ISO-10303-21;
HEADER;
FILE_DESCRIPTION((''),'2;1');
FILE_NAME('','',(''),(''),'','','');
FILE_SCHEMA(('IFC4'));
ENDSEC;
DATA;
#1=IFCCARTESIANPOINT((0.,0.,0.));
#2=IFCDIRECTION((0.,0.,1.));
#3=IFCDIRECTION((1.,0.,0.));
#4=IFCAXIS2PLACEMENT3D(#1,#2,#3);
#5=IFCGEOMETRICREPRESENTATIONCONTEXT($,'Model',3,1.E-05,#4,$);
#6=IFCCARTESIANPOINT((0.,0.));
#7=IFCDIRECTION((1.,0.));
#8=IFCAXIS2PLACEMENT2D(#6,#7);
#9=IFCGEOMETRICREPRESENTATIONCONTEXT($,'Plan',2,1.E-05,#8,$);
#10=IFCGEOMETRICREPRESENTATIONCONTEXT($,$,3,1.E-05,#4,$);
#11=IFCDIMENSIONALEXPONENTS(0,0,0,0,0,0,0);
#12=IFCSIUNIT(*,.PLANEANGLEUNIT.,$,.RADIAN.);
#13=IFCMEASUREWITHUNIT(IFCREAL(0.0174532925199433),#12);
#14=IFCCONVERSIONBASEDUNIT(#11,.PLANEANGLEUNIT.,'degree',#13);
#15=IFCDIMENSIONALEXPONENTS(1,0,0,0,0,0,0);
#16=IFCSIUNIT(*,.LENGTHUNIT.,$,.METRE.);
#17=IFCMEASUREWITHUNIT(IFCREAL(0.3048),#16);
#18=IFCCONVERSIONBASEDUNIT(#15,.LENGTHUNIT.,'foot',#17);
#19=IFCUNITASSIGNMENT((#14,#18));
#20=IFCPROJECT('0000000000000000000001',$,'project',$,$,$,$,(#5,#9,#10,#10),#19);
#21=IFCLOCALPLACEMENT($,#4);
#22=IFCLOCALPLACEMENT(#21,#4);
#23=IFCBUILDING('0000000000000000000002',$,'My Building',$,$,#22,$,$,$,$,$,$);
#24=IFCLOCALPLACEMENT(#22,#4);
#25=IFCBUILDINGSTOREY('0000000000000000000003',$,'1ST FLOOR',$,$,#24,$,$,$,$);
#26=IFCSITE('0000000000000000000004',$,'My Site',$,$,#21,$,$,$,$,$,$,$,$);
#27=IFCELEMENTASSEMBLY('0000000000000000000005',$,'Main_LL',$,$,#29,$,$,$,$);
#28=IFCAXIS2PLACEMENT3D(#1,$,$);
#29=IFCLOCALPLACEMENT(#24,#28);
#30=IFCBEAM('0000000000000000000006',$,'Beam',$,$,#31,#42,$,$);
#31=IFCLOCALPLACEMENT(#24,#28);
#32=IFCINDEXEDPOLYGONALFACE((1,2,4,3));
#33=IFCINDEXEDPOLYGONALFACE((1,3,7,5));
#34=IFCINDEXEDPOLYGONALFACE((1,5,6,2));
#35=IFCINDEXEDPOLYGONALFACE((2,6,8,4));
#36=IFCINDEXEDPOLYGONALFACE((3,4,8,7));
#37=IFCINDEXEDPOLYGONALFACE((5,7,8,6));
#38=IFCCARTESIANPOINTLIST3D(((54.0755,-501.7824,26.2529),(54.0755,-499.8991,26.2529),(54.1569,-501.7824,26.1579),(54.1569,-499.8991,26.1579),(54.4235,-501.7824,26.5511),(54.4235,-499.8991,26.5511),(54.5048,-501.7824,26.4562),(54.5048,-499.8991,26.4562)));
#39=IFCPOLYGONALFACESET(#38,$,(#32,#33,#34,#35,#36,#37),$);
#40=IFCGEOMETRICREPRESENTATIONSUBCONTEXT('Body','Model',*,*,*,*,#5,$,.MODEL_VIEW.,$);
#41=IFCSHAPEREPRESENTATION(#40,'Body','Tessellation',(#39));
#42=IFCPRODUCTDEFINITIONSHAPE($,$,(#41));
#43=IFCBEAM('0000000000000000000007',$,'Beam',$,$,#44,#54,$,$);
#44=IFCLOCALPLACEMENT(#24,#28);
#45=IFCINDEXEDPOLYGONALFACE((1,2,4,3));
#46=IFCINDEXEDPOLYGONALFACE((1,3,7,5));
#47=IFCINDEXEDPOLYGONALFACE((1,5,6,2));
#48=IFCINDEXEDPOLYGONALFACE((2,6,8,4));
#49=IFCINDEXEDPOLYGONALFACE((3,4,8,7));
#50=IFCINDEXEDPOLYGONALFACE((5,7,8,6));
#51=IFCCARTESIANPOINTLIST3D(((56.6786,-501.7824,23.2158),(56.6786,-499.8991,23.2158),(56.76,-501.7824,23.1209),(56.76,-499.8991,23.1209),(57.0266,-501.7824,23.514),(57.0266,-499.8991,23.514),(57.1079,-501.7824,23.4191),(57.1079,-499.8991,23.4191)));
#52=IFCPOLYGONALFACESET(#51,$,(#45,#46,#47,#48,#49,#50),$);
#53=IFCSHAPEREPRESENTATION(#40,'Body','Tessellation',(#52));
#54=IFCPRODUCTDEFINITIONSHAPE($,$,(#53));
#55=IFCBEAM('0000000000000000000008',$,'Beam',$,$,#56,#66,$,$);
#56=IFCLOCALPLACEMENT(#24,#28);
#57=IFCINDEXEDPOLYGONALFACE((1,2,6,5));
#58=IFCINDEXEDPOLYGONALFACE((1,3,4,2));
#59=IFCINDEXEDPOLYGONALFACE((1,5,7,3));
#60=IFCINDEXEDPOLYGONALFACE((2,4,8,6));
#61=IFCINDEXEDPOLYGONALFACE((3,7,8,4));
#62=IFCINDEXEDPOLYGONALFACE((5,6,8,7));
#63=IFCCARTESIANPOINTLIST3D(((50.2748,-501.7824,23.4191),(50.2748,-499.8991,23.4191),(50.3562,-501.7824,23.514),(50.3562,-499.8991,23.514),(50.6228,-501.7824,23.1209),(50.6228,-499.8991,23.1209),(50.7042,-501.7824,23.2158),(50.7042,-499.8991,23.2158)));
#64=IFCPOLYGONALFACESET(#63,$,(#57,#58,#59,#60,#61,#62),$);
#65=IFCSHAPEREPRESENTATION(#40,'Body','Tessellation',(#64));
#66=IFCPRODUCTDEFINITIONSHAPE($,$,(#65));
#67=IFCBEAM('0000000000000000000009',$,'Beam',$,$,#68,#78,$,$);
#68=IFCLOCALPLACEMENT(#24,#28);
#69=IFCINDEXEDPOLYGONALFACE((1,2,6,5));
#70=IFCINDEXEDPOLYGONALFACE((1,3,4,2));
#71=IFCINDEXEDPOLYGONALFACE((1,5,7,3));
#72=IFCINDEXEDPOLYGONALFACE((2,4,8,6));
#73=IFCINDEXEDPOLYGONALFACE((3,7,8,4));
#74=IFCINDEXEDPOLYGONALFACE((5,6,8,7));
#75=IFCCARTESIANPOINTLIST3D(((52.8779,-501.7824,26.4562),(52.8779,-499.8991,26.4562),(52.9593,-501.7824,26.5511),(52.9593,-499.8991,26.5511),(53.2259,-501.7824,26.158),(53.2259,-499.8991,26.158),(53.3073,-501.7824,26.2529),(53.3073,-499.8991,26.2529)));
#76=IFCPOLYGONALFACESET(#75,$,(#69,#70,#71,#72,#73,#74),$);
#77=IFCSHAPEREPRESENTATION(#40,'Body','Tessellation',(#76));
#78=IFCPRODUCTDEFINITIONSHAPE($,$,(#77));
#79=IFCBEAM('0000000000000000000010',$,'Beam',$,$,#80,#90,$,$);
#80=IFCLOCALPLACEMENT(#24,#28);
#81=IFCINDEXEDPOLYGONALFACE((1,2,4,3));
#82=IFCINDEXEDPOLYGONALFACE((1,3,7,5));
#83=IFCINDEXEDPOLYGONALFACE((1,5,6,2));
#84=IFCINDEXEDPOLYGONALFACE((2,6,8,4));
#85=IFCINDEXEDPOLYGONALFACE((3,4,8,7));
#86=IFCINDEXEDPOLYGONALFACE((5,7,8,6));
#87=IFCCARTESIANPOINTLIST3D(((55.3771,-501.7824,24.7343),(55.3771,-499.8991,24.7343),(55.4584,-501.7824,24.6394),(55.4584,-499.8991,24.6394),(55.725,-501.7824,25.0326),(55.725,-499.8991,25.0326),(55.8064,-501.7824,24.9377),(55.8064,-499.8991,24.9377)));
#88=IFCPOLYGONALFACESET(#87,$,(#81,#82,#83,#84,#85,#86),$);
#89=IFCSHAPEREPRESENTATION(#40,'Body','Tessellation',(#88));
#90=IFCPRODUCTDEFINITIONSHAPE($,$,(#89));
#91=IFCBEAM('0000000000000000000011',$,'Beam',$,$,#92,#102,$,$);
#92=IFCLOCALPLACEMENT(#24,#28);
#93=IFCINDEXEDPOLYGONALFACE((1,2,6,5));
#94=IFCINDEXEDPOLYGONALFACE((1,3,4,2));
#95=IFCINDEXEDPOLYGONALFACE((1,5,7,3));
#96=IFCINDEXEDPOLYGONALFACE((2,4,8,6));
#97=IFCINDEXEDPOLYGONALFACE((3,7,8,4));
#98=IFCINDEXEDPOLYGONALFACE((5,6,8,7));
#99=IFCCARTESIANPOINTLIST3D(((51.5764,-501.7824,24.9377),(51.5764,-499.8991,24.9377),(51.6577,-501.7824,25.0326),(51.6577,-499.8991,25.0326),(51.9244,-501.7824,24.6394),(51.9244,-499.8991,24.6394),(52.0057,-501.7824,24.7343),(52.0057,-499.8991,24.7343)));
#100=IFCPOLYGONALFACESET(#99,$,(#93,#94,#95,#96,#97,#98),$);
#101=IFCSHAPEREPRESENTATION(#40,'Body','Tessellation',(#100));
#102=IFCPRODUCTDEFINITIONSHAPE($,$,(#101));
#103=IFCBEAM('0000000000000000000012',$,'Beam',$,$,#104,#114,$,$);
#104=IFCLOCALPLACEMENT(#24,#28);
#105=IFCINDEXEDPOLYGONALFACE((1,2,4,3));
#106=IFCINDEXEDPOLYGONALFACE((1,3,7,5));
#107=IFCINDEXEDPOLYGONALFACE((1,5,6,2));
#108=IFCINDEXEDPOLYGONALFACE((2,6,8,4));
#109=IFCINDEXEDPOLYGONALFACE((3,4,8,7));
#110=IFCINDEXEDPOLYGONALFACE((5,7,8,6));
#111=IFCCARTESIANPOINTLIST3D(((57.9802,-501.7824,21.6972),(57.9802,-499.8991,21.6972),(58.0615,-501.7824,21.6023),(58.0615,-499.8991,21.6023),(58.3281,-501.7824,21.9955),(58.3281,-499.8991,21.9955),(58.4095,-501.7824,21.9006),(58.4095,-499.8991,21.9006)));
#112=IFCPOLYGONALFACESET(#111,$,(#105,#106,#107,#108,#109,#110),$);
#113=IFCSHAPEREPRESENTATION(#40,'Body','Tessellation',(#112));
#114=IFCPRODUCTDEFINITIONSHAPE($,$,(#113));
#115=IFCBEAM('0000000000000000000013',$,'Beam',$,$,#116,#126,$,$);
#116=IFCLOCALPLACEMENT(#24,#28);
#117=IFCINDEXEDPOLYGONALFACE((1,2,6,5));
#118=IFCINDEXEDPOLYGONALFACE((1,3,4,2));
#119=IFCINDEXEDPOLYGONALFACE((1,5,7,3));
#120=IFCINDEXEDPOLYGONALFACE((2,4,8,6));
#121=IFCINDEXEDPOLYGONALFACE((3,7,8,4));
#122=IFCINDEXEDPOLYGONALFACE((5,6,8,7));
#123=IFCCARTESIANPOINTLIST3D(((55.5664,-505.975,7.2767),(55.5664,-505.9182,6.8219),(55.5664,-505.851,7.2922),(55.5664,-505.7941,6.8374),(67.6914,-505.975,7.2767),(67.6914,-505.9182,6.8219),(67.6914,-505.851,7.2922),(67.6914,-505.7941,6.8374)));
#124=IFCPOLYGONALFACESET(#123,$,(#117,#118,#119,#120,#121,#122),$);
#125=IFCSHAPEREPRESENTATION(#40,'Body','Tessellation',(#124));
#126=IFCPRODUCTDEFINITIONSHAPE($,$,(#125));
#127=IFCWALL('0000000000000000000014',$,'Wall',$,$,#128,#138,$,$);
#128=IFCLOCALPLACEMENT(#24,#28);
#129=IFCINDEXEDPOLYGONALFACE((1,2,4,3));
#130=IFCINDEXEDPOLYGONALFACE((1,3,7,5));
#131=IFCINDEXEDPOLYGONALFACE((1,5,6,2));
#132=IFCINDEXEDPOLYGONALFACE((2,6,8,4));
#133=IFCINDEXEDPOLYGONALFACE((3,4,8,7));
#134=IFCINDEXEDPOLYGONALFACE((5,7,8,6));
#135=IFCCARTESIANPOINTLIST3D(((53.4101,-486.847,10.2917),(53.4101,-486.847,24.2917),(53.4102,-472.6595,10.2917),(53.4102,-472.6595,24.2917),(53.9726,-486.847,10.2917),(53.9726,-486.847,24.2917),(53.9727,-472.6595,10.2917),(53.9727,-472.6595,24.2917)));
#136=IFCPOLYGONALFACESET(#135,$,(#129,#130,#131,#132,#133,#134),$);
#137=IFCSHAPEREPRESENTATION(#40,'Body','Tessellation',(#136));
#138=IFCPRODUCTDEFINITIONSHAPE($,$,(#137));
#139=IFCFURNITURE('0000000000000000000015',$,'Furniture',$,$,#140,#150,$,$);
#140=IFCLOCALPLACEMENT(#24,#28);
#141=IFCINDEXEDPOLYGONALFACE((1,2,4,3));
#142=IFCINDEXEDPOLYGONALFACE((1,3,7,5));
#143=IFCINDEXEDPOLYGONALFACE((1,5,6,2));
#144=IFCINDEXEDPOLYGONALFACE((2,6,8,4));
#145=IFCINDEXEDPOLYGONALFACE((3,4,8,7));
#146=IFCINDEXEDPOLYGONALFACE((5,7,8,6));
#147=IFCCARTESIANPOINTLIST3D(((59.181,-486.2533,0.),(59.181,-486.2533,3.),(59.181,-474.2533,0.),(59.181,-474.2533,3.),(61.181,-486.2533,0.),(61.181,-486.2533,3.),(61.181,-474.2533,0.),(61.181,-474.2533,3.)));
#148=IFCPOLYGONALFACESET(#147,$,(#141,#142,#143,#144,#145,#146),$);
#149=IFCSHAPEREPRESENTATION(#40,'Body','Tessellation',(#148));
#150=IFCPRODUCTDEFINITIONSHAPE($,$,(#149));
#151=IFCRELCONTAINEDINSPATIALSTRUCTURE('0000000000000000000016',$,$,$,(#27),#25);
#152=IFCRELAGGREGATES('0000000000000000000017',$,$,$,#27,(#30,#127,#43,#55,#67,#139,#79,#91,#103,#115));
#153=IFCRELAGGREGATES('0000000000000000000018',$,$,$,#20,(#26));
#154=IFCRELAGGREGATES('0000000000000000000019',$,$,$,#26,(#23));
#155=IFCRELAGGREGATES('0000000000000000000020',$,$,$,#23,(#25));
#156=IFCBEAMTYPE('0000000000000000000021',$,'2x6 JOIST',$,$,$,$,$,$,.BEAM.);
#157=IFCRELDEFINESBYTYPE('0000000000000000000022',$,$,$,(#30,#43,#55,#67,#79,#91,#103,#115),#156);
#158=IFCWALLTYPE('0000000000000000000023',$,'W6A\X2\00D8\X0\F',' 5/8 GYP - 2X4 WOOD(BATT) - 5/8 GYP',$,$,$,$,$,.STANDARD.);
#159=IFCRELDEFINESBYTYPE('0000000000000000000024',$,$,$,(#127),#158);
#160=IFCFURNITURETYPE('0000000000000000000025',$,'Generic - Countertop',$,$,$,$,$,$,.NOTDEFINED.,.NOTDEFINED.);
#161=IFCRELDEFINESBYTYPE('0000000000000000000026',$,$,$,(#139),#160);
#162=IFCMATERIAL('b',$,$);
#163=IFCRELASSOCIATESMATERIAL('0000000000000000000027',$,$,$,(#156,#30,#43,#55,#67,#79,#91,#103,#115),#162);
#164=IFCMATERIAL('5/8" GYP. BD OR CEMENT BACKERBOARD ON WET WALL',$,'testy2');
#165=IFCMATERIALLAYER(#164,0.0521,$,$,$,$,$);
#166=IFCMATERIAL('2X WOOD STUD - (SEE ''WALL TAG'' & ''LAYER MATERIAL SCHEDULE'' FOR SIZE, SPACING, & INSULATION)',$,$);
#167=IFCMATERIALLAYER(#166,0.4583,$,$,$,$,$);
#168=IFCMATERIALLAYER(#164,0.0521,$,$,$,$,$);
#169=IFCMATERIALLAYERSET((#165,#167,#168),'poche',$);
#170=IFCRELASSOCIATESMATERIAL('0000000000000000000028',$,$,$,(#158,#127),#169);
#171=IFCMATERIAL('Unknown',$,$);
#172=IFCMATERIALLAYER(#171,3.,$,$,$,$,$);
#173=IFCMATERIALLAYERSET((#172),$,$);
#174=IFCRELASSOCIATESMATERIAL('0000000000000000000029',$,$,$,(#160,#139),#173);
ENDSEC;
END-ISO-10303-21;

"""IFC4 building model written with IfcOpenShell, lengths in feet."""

from ifc_helpers import new_model, entity, si_unit, converted_unit, frame, origin_with_axes, origin_2d_with_axis, place, context, subcontext, project, spatial, line, indexed_curve, rectangle, outline, extrude, material, layer, layer_set, layer_usage, material_profile, profile_set, profile_usage, type_object, element, aggregate, save


model = new_model("IFC4")

# Units and contexts
model_context = context("Model", 3, precision=1e-05, world=origin_with_axes())
plan_context = context("Plan", 2, precision=1e-05, world=origin_2d_with_axis())
context_of_model = context(None, 3, precision=1e-05, world=origin_with_axes())
body_context = subcontext(model_context, "Body", "Model", "MODEL_VIEW")
ifc_project = project(units=[converted_unit("PLANEANGLEUNIT", "degree", entity("IfcReal", 0.0174532925199433), si_unit("PLANEANGLEUNIT", "RADIAN"), dimensions=[0, 0, 0, 0, 0, 0, 0]), converted_unit("LENGTHUNIT", "foot", entity("IfcReal", 0.3048), si_unit("LENGTHUNIT", "METRE"), dimensions=[1, 0, 0, 0, 0, 0, 0])], contexts=[model_context, plan_context, context_of_model, context_of_model])

# Site, building, storey
site_placement = place(None, origin_with_axes())
site = spatial("IfcSite", under=ifc_project, at=site_placement, Name="My Site")
building_placement = place(site_placement, origin_with_axes())
building = spatial("IfcBuilding", under=site, at=building_placement, Name="My Building")
storey_placement = place(building_placement, origin_with_axes())
storey = spatial("IfcBuildingStorey", under=building, at=storey_placement, Name="1ST FLOOR")

# Element assembly, beams, wall, furniture
assembly_placement = place(storey_placement, origin_with_axes())
assembly = element("IfcElementAssembly", 1, at=assembly_placement, inside=storey, Name="Main_LL")
ifc_material_1 = material(Name="b")
ifc_material_profile_1 = material_profile(ifc_material_1, rectangle(XDim=0.125, YDim=0.4583))
ifc_profile_set_1 = profile_set([ifc_material_profile_1])
ifc_profile_usage_1 = profile_usage(ifc_profile_set_1, cardinal=8)
beam_type_1 = type_object("IfcBeamType", Name="2x6 JOIST", PredefinedType="BEAM", material=ifc_profile_set_1)
beam_1_placement = place(assembly_placement, frame((54.4642, -499.8991, 26.5037), z_axis=(0.0, -1.0, 0.0), x_axis=(0.650774, 0.0, -0.759271)))
beam_1 = element("IfcBeam", 2, at=beam_1_placement, type_object=beam_type_1, material=ifc_profile_usage_1, Name="Beam", context=body_context, shape_type="SweptSolid", body=[
    extrude(rectangle(XDim=0.125, YDim=0.4583), frame((0.0, -0.2291, 0.0)), (0.0, 0.0, 1.0), 1.8833),
])
ifc_profile_usage_2 = profile_usage(ifc_profile_set_1, cardinal=8)
beam_2_placement = place(assembly_placement, frame((57.0673, -499.8991, 23.4666), z_axis=(0.0, -1.0, 0.0), x_axis=(0.650774, 0.0, -0.759271)))
beam_2 = element("IfcBeam", 3, at=beam_2_placement, type_object=beam_type_1, material=ifc_profile_usage_2, Name="Beam", context=body_context, shape_type="SweptSolid", body=[
    extrude(rectangle(XDim=0.125, YDim=0.4583), frame((0.0, -0.2291, 0.0)), (0.0, 0.0, 1.0), 1.8833),
])
ifc_profile_usage_3 = profile_usage(ifc_profile_set_1, cardinal=8)
beam_3_placement = place(assembly_placement, frame((50.3155, -499.8991, 23.4666), z_axis=(0.0, -1.0, 0.0), x_axis=(0.650774, 0.0, 0.759271)))
beam_3 = element("IfcBeam", 4, at=beam_3_placement, type_object=beam_type_1, material=ifc_profile_usage_3, Name="Beam", context=body_context, shape_type="SweptSolid", body=[
    extrude(rectangle(XDim=0.125, YDim=0.4583), frame((0.0, -0.2291, 0.0)), (0.0, 0.0, 1.0), 1.8833),
])
ifc_profile_usage_4 = profile_usage(ifc_profile_set_1, cardinal=8)
beam_4_placement = place(assembly_placement, frame((52.9186, -499.8991, 26.5037), z_axis=(0.0, -1.0, 0.0), x_axis=(0.650774, 0.0, 0.759271)))
beam_4 = element("IfcBeam", 5, at=beam_4_placement, type_object=beam_type_1, material=ifc_profile_usage_4, Name="Beam", context=body_context, shape_type="SweptSolid", body=[
    extrude(rectangle(XDim=0.125, YDim=0.4583), frame((0.0, -0.2291, 0.0)), (0.0, 0.0, 1.0), 1.8833),
])
ifc_profile_usage_5 = profile_usage(ifc_profile_set_1, cardinal=8)
beam_5_placement = place(assembly_placement, frame((55.7657, -499.8991, 24.9851), z_axis=(0.0, -1.0, 0.0), x_axis=(0.650774, 0.0, -0.759271)))
beam_5 = element("IfcBeam", 6, at=beam_5_placement, type_object=beam_type_1, material=ifc_profile_usage_5, Name="Beam", context=body_context, shape_type="SweptSolid", body=[
    extrude(rectangle(XDim=0.125, YDim=0.4583), frame((0.0, -0.2291, 0.0)), (0.0, 0.0, 1.0), 1.8833),
])
ifc_profile_usage_6 = profile_usage(ifc_profile_set_1, cardinal=8)
beam_6_placement = place(assembly_placement, frame((51.6171, -499.8991, 24.9851), z_axis=(0.0, -1.0, 0.0), x_axis=(0.650774, 0.0, 0.759271)))
beam_6 = element("IfcBeam", 7, at=beam_6_placement, type_object=beam_type_1, material=ifc_profile_usage_6, Name="Beam", context=body_context, shape_type="SweptSolid", body=[
    extrude(rectangle(XDim=0.125, YDim=0.4583), frame((0.0, -0.2291, 0.0)), (0.0, 0.0, 1.0), 1.8833),
])
ifc_profile_usage_7 = profile_usage(ifc_profile_set_1, cardinal=8)
beam_7_placement = place(assembly_placement, frame((58.3688, -499.8991, 21.948), z_axis=(0.0, -1.0, 0.0), x_axis=(0.650774, 0.0, -0.759271)))
beam_7 = element("IfcBeam", 8, at=beam_7_placement, type_object=beam_type_1, material=ifc_profile_usage_7, Name="Beam", context=body_context, shape_type="SweptSolid", body=[
    extrude(rectangle(XDim=0.125, YDim=0.4583), frame((0.0, -0.2291, 0.0)), (0.0, 0.0, 1.0), 1.8833),
])
ifc_profile_usage_8 = profile_usage(ifc_profile_set_1, cardinal=5)
beam_8_placement = place(assembly_placement, frame((55.5664, -505.8846, 7.0571), z_axis=(1.0, 0.0, 0.0), x_axis=(0.0, 0.992267, 0.124121)))
beam_8 = element("IfcBeam", 9, at=beam_8_placement, type_object=beam_type_1, material=ifc_profile_usage_8, Name="Beam", context=body_context, shape_type="SweptSolid", body=[
    extrude(rectangle(XDim=0.125, YDim=0.4583), origin_with_axes(), (0.0, 0.0, 1.0), 12.125),
])
ifc_material_2 = material(Name="5/8\" GYP. BD OR CEMENT BACKERBOARD ON WET WALL", Category="testy2")
ifc_material_3 = material(Name="2X WOOD STUD - (SEE 'WALL TAG' & 'LAYER MATERIAL SCHEDULE' FOR SIZE, SPACING, & INSULATION)")
ifc_layer_1 = layer(ifc_material_2, 0.0521)
ifc_layer_2 = layer(ifc_material_3, 0.4583)
ifc_layer_3 = layer(ifc_material_2, 0.0521)
ifc_layer_set_1 = layer_set([ifc_layer_1, ifc_layer_2, ifc_layer_3], Name="poche")
ifc_layer_usage_1 = layer_usage(ifc_layer_set_1, "AXIS2", "POSITIVE", 0.0)
wall_type_1 = type_object("IfcWallType", Name="W6AØF", Description=" 5/8 GYP - 2X4 WOOD(BATT) - 5/8 GYP", PredefinedType="STANDARD", material=ifc_layer_set_1)
wall_1_placement = place(assembly_placement, frame((53.9726, -486.847, 10.2917), z_axis=(0.0, 0.0, 1.0), x_axis=(0.0, 1.0, 0.0)))
wall_1 = element("IfcWall", 10, at=wall_1_placement, type_object=wall_type_1, material=ifc_layer_usage_1, Name="Wall", context=body_context, shape_type="SweptSolid", body=[
    extrude(outline(indexed_curve([(0.0, 0.0), (0.0, 0.5625), (14.1875, 0.5625), (14.1875, 0.0), (0.0, 0.0)], self_intersect=False)), origin_with_axes(), (0.0, 0.0, 1.0), 14.0),
])
ifc_material_4 = material(Name="Unknown")
ifc_layer_4 = layer(ifc_material_4, 3.0)
ifc_layer_set_2 = layer_set([ifc_layer_4])
furniture_type_1 = type_object("IfcFurnitureType", Name="Generic - Countertop", AssemblyPlace="NOTDEFINED", PredefinedType="NOTDEFINED", material=ifc_layer_set_2)
ifc_layer_usage_2 = layer_usage(ifc_layer_set_2, "AXIS3", "POSITIVE", 0.0)
furniture_1_placement = place(assembly_placement, frame((59.181, -486.2533, 0.0), z_axis=(0.0, 0.0, 1.0), x_axis=(1.0, 0.0, 0.0)))
furniture_1 = element("IfcFurniture", 11, at=furniture_1_placement, type_object=furniture_type_1, material=ifc_layer_usage_2, Name="Furniture", context=body_context, shape_type="SweptSolid", body=[
    extrude(outline(indexed_curve([(0.0, 12.0), (2.0, 12.0), (2.0, 0.0), (0.0, 0.0)], segments=[line(4, 1), line(1, 2), line(2, 3), line(3, 4)], self_intersect=False)), None, (0.0, 0.0, 1.0), 3.0),
])
aggregate(assembly, [beam_1, wall_1, beam_2, beam_3, beam_4, furniture_1, beam_5, beam_6, beam_7, beam_8])

save(model, "model.ifc")
